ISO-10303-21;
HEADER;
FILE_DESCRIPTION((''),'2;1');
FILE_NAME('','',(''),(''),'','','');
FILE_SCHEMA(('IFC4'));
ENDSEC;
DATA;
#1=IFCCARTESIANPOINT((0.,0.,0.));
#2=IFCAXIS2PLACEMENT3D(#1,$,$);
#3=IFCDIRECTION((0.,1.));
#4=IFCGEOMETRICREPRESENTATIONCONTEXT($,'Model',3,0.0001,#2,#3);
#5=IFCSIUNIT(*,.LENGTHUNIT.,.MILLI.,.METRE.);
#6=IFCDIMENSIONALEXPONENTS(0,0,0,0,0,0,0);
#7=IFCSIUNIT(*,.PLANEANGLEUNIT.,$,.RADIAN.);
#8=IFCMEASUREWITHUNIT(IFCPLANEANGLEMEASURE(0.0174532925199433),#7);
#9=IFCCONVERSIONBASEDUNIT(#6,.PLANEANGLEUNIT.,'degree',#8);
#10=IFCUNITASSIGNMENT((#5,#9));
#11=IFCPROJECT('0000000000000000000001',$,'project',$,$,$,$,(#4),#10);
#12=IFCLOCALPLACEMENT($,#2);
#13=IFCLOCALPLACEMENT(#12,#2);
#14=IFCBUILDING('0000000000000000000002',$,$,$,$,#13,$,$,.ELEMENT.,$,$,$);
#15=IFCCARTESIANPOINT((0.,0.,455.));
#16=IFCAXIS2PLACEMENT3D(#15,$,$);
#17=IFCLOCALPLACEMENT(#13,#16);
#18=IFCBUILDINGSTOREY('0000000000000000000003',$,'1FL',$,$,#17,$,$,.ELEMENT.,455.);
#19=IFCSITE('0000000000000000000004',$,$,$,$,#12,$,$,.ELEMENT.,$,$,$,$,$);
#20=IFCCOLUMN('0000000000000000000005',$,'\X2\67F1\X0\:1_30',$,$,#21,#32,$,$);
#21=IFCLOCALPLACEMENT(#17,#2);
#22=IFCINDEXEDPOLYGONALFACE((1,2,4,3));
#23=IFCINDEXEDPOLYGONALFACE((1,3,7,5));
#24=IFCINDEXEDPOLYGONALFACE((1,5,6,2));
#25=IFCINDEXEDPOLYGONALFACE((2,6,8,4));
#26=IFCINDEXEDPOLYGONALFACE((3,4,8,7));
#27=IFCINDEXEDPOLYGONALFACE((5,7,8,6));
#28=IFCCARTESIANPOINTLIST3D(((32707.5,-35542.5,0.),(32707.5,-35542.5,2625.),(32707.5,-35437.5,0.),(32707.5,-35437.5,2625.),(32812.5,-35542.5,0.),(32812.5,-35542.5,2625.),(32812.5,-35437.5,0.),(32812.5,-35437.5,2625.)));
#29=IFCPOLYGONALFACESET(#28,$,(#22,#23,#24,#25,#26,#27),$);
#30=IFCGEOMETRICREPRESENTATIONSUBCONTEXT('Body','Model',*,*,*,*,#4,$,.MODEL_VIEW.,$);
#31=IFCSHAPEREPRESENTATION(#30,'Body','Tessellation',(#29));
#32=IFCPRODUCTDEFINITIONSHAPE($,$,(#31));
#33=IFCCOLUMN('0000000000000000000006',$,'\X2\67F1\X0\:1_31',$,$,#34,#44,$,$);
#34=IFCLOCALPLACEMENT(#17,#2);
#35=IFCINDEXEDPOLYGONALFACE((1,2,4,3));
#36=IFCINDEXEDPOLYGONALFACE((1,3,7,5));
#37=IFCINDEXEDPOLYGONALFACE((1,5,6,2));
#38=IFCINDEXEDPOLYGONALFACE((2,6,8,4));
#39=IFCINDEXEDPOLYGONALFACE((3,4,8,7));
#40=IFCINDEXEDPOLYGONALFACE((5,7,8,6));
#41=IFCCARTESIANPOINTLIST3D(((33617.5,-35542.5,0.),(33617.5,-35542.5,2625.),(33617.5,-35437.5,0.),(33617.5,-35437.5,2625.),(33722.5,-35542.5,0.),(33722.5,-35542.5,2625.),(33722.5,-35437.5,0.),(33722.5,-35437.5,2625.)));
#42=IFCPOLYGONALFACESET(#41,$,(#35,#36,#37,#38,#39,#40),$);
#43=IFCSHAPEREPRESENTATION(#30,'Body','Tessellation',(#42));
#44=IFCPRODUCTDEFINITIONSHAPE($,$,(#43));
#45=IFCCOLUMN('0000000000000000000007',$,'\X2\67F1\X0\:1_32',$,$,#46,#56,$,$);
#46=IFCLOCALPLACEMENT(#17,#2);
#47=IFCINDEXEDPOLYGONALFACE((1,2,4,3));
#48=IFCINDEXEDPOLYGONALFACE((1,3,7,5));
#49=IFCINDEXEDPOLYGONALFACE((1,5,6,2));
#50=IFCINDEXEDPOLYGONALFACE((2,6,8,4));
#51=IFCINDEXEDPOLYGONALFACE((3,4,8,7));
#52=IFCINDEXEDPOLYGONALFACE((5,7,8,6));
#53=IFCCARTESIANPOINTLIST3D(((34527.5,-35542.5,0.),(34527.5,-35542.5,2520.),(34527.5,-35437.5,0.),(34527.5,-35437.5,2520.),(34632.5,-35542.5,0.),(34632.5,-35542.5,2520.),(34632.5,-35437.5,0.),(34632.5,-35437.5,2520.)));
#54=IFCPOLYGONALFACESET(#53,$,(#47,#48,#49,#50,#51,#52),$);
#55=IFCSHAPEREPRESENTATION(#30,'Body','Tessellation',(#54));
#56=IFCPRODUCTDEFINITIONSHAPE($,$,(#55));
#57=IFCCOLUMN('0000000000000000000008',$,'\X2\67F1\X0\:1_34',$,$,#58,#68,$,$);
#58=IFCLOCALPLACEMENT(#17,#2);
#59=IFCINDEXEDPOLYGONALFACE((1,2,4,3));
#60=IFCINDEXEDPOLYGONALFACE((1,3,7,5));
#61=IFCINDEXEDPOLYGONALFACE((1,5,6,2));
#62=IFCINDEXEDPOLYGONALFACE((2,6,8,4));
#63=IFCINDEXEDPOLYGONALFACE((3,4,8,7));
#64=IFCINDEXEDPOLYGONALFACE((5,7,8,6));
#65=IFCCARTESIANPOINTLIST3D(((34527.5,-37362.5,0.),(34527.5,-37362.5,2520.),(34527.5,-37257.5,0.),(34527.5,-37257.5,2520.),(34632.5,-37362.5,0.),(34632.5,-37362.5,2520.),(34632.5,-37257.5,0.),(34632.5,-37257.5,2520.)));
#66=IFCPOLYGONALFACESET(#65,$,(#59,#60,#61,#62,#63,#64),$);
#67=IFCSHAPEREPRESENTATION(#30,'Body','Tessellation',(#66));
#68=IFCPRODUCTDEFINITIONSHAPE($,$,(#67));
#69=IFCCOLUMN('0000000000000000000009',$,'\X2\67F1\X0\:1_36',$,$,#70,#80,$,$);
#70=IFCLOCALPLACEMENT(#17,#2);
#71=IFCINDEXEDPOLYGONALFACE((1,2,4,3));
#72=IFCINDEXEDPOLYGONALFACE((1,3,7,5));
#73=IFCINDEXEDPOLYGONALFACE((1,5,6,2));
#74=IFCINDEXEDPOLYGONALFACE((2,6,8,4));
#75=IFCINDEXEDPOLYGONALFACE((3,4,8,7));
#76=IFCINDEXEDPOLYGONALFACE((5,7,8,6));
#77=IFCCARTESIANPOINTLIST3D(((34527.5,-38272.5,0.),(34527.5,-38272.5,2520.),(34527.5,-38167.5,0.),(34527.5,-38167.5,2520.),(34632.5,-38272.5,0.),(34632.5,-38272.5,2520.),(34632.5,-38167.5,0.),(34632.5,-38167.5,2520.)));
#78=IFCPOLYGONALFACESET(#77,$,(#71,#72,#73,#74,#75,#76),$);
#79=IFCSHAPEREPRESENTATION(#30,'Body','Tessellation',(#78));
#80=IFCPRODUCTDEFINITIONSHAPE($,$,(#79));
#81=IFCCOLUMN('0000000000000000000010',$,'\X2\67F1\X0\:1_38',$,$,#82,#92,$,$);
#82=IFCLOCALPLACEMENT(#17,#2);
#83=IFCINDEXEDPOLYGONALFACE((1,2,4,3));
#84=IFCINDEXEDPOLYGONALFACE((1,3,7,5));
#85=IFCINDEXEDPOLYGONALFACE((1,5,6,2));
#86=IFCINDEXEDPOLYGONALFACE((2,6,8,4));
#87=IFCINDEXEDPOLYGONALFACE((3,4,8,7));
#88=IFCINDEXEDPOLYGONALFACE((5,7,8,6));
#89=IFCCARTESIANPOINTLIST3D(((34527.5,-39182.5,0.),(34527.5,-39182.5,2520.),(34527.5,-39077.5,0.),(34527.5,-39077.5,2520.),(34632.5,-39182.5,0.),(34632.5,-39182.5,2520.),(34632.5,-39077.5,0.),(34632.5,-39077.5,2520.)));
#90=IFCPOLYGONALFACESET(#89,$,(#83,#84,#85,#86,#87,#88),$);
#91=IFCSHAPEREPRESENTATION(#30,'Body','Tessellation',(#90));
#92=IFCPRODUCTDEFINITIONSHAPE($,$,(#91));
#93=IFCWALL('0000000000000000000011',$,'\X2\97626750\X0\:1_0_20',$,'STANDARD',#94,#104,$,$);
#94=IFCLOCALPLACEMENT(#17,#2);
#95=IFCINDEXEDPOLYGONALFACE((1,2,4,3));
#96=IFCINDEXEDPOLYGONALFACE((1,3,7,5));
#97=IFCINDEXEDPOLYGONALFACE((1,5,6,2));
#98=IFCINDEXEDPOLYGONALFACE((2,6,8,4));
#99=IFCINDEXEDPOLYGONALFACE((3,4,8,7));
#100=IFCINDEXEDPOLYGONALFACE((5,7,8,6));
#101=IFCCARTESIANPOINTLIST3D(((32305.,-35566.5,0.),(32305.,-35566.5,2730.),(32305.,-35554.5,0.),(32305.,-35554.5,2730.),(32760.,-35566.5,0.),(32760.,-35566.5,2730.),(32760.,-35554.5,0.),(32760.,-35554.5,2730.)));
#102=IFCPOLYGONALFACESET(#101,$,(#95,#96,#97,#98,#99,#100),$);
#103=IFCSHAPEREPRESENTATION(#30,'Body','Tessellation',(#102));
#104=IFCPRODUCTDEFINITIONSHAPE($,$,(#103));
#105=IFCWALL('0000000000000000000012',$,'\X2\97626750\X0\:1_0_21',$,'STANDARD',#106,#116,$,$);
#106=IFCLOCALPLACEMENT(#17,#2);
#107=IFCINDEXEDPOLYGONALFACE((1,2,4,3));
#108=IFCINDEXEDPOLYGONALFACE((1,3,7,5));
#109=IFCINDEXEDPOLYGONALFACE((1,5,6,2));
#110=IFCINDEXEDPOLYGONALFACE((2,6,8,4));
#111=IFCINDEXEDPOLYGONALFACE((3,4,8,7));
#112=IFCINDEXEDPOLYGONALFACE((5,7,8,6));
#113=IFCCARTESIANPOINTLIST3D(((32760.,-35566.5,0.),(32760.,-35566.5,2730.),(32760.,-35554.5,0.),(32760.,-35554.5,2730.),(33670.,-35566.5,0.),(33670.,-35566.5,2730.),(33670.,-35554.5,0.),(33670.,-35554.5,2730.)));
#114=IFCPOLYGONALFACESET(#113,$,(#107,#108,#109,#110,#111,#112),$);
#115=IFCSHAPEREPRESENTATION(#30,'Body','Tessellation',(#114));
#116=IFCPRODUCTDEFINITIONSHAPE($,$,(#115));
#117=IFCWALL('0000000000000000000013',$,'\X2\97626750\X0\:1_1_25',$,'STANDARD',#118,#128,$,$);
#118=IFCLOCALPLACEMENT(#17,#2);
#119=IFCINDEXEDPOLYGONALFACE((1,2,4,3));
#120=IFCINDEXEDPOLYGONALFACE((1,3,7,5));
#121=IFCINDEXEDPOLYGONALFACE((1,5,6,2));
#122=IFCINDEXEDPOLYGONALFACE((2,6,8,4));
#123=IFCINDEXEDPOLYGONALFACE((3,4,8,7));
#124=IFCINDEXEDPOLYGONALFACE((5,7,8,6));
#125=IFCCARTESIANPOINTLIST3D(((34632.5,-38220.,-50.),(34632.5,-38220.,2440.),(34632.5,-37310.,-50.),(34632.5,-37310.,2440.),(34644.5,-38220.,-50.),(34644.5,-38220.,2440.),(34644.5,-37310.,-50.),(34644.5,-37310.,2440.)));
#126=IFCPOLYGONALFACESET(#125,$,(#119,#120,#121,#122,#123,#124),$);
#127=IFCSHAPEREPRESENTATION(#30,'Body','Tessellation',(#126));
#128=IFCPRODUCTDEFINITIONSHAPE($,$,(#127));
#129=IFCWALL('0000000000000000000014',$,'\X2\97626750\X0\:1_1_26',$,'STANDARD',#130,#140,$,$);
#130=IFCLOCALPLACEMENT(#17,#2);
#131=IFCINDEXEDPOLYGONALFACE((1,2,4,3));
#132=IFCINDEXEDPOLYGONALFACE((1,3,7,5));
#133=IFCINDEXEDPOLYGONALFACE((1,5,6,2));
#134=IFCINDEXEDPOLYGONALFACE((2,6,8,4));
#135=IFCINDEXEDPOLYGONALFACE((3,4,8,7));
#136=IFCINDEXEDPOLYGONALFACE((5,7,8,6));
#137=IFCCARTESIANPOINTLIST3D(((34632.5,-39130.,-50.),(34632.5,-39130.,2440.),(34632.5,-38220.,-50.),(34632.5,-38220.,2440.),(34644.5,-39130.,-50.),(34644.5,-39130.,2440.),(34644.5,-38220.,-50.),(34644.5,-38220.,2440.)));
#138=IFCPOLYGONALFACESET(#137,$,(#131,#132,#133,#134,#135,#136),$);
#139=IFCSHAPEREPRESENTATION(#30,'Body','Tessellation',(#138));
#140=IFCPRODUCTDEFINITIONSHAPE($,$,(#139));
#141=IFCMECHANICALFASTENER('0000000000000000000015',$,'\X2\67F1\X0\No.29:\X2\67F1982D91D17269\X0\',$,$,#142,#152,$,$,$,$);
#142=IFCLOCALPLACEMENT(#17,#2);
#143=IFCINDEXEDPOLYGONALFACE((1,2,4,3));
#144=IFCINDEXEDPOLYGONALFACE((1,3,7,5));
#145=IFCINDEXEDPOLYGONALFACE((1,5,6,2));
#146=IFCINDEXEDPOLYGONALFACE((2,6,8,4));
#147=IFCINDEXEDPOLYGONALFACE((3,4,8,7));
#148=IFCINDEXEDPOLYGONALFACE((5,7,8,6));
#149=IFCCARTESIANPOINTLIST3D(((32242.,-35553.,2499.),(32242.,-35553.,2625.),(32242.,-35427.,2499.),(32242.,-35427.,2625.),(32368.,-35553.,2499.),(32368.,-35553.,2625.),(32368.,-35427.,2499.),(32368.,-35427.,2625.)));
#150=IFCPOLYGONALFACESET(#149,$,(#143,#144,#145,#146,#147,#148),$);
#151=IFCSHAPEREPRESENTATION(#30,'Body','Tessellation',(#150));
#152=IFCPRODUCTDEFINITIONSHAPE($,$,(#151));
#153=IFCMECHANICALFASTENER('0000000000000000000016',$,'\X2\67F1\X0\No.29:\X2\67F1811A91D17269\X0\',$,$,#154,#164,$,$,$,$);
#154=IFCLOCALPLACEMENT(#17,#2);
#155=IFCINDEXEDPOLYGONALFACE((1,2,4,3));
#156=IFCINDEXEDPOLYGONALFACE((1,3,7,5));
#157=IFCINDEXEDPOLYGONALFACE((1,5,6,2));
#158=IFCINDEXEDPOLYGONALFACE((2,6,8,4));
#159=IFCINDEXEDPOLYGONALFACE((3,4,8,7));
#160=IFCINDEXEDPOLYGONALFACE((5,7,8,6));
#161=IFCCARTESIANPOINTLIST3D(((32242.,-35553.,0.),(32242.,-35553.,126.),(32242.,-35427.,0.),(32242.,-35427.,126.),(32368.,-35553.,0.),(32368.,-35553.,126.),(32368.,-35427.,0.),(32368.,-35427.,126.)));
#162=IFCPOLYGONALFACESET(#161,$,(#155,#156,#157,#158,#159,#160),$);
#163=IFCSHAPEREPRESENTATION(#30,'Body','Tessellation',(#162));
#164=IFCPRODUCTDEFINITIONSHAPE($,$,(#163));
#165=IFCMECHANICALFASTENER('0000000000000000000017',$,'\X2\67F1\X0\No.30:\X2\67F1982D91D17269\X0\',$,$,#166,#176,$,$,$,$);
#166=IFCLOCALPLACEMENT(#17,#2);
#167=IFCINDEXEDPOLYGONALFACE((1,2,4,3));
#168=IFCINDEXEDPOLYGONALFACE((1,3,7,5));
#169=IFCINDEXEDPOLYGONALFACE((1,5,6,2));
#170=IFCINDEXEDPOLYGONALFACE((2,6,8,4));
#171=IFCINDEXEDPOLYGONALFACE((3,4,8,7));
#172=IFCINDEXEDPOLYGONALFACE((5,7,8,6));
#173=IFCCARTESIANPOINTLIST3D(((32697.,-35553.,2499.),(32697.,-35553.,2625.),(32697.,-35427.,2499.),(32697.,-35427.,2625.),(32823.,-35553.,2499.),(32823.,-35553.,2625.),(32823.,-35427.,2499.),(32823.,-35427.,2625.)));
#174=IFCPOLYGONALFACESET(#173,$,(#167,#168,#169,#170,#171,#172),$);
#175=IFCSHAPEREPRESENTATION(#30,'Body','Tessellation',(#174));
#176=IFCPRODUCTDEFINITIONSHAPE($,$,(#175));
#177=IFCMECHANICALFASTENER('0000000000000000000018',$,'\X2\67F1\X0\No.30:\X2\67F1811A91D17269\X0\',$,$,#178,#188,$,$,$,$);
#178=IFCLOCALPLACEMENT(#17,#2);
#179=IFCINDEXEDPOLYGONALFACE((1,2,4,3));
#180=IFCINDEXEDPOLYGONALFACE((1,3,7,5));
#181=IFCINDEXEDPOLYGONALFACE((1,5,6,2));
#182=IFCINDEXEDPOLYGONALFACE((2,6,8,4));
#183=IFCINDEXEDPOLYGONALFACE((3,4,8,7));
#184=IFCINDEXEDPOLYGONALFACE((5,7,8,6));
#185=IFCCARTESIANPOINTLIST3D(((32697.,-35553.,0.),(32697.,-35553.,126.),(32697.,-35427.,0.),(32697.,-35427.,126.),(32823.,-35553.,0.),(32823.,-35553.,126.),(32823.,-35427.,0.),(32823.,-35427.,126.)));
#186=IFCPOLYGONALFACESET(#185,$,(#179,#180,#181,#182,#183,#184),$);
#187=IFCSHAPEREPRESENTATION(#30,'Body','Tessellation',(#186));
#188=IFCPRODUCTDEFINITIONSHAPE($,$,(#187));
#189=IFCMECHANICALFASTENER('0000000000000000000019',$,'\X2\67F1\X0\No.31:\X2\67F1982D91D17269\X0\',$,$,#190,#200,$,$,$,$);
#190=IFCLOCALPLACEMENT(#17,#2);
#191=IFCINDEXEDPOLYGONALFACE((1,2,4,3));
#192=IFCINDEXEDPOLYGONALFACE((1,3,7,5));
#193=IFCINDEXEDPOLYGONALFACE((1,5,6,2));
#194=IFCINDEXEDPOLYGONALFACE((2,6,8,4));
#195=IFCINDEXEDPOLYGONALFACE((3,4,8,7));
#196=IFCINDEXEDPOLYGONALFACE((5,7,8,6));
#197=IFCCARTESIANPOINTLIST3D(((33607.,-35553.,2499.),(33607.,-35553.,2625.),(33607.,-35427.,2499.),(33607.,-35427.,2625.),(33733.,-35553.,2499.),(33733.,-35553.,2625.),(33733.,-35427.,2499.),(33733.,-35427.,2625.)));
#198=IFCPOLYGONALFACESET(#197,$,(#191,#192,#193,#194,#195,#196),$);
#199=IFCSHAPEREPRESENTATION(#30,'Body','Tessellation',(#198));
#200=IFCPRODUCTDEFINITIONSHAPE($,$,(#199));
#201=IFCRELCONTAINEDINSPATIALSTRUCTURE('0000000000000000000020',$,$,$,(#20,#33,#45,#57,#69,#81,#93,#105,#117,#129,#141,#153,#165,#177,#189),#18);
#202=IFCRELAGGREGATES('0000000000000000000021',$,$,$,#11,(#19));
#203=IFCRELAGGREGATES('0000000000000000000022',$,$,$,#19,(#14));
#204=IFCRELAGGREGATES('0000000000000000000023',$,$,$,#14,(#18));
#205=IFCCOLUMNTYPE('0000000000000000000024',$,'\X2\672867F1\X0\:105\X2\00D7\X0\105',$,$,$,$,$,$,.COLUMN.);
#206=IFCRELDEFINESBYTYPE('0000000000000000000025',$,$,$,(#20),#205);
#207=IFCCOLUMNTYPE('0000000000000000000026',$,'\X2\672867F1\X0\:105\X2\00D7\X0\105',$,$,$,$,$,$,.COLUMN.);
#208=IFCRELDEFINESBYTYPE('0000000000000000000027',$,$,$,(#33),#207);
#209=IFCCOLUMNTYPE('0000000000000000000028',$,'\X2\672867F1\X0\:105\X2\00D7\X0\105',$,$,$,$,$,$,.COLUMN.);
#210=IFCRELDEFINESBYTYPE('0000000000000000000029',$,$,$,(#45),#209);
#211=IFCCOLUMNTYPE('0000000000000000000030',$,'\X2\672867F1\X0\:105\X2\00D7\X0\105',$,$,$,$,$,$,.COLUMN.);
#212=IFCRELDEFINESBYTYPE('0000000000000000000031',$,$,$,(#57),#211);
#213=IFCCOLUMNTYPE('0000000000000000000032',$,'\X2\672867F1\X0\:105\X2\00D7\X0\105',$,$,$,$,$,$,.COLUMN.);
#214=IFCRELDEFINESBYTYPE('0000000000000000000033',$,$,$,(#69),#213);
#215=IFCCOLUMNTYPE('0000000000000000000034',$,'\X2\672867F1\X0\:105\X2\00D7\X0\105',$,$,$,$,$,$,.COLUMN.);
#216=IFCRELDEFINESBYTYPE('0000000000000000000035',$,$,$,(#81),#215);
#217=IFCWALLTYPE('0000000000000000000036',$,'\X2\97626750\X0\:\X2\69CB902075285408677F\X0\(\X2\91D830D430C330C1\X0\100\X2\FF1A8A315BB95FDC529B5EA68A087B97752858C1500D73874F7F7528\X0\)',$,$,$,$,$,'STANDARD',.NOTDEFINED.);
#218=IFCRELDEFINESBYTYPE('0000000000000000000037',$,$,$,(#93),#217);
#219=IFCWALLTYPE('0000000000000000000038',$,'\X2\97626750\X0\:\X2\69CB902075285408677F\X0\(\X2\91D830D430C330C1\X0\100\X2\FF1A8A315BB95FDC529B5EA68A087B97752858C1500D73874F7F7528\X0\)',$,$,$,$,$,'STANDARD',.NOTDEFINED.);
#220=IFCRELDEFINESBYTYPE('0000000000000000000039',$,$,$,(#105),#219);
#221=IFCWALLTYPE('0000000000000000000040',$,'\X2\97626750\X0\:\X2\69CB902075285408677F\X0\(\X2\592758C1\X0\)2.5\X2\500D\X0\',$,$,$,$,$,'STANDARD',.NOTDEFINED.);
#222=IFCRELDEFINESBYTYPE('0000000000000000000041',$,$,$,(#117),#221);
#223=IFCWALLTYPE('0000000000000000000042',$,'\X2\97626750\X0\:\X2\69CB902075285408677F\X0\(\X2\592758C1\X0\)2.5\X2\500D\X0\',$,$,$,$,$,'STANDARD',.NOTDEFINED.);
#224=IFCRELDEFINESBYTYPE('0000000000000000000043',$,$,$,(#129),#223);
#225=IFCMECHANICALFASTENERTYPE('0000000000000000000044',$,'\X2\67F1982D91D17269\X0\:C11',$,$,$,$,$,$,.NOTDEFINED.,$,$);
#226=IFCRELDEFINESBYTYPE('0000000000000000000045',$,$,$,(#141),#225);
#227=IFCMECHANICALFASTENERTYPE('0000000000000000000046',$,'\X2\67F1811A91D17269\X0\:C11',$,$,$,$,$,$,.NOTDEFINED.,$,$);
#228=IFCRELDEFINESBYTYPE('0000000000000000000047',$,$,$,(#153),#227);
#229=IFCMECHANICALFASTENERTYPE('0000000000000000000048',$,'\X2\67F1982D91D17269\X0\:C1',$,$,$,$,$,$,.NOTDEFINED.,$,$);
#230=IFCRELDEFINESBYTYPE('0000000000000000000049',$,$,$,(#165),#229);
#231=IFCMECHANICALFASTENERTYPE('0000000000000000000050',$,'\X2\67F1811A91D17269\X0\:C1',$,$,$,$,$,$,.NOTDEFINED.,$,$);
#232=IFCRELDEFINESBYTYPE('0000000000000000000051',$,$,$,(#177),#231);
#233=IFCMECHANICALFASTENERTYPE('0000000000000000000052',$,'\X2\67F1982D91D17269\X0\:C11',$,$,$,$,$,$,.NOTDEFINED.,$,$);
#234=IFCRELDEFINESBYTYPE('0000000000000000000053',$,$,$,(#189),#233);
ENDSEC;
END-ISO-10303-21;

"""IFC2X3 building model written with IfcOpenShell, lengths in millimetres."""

from ifc_helpers import new_model, entity, si_unit, converted_unit, direction, frame, origin, origin_with_axes, origin_2d, place, context, subcontext, project, spatial, polyline, rectangle, outline, extrude, type_object, element, save


model = new_model("IFC2X3")

# Units and contexts
model_context = context("Model", 3, precision=0.0001, world=origin(), true_north=direction((0.0, 1.0)))
body_context = subcontext(model_context, "Body", "Model", "MODEL_VIEW")
ifc_project = project(units=[si_unit("LENGTHUNIT", "METRE", prefix="MILLI"), converted_unit("PLANEANGLEUNIT", "degree", entity("IfcPlaneAngleMeasure", 0.0174532925199433), si_unit("PLANEANGLEUNIT", "RADIAN"), dimensions=[0, 0, 0, 0, 0, 0, 0])], contexts=[model_context])

# Site, building, storey
site_placement = place(None, origin())
site = spatial("IfcSite", under=ifc_project, at=site_placement, CompositionType="ELEMENT")
building_placement = place(site_placement, origin())
building = spatial("IfcBuilding", under=site, at=building_placement, CompositionType="ELEMENT")
storey_placement = place(building_placement, frame((0.0, 0.0, 455.0)))
storey = spatial("IfcBuildingStorey", under=building, at=storey_placement, Name="1FL", CompositionType="ELEMENT", Elevation=455.0)

# Columns
column_type_1 = type_object("IfcColumnType", Name="木柱:105×105", PredefinedType="COLUMN")
column_1_placement = place(storey_placement, frame((32760.0, -35490.0, 0.0)))
element("IfcColumn", 1, at=column_1_placement, inside=storey, type_object=column_type_1, Name="柱:1_30", context=body_context, shape_type="SweptSolid", body=[
    extrude(rectangle(XDim=105.0, YDim=105.0, at=origin_2d()), origin_with_axes(), (0.0, 0.0, 1.0), 2625.0),
])
column_type_2 = type_object("IfcColumnType", Name="木柱:105×105", PredefinedType="COLUMN")
column_2_placement = place(storey_placement, frame((33670.0, -35490.0, 0.0)))
element("IfcColumn", 2, at=column_2_placement, inside=storey, type_object=column_type_2, Name="柱:1_31", context=body_context, shape_type="SweptSolid", body=[
    extrude(rectangle(XDim=105.0, YDim=105.0, at=origin_2d()), origin_with_axes(), (0.0, 0.0, 1.0), 2625.0),
])
column_type_3 = type_object("IfcColumnType", Name="木柱:105×105", PredefinedType="COLUMN")
column_3_placement = place(storey_placement, frame((34580.0, -35490.0, 0.0)))
element("IfcColumn", 3, at=column_3_placement, inside=storey, type_object=column_type_3, Name="柱:1_32", context=body_context, shape_type="SweptSolid", body=[
    extrude(rectangle(XDim=105.0, YDim=105.0, at=origin_2d()), origin_with_axes(), (0.0, 0.0, 1.0), 2520.0),
])
column_type_4 = type_object("IfcColumnType", Name="木柱:105×105", PredefinedType="COLUMN")
column_4_placement = place(storey_placement, frame((34580.0, -37310.0, 0.0)))
element("IfcColumn", 4, at=column_4_placement, inside=storey, type_object=column_type_4, Name="柱:1_34", context=body_context, shape_type="SweptSolid", body=[
    extrude(rectangle(XDim=105.0, YDim=105.0, at=origin_2d()), origin_with_axes(), (0.0, 0.0, 1.0), 2520.0),
])
column_type_5 = type_object("IfcColumnType", Name="木柱:105×105", PredefinedType="COLUMN")
column_5_placement = place(storey_placement, frame((34580.0, -38220.0, 0.0)))
element("IfcColumn", 5, at=column_5_placement, inside=storey, type_object=column_type_5, Name="柱:1_36", context=body_context, shape_type="SweptSolid", body=[
    extrude(rectangle(XDim=105.0, YDim=105.0, at=origin_2d()), origin_with_axes(), (0.0, 0.0, 1.0), 2520.0),
])
column_type_6 = type_object("IfcColumnType", Name="木柱:105×105", PredefinedType="COLUMN")
column_6_placement = place(storey_placement, frame((34580.0, -39130.0, 0.0)))
element("IfcColumn", 6, at=column_6_placement, inside=storey, type_object=column_type_6, Name="柱:1_38", context=body_context, shape_type="SweptSolid", body=[
    extrude(rectangle(XDim=105.0, YDim=105.0, at=origin_2d()), origin_with_axes(), (0.0, 0.0, 1.0), 2520.0),
])

# Walls
wall_type_1 = type_object("IfcWallType", Name="面材:構造用合板(釘ピッチ100：許容応力度計算用壁倍率使用)", ElementType="STANDARD", PredefinedType="NOTDEFINED")
wall_1_placement = place(storey_placement, frame((32532.5, -35554.5, 0.0), z_axis=(0.0, -1.0, 0.0), x_axis=(1.0, 0.0, 0.0)))
element("IfcWall", 7, at=wall_1_placement, inside=storey, type_object=wall_type_1, Name="面材:1_0_20", ObjectType="STANDARD", context=body_context, shape_type="SweptSolid", body=[
    extrude(outline(polyline([(227.5, 0.0, 0.0), (-227.5, 0.0, 0.0), (-227.5, 2730.0, 0.0), (227.5, 2730.0, 0.0), (227.5, 0.0, 0.0)])), origin_with_axes(), (0.0, 0.0, 1.0), 12.0),
])
wall_type_2 = type_object("IfcWallType", Name="面材:構造用合板(釘ピッチ100：許容応力度計算用壁倍率使用)", ElementType="STANDARD", PredefinedType="NOTDEFINED")
wall_2_placement = place(storey_placement, frame((33215.0, -35554.5, 0.0), z_axis=(0.0, -1.0, 0.0), x_axis=(1.0, 0.0, 0.0)))
element("IfcWall", 8, at=wall_2_placement, inside=storey, type_object=wall_type_2, Name="面材:1_0_21", ObjectType="STANDARD", context=body_context, shape_type="SweptSolid", body=[
    extrude(outline(polyline([(455.0, 0.0, 0.0), (-455.0, 0.0, 0.0), (-455.0, 2730.0, 0.0), (455.0, 2730.0, 0.0), (455.0, 0.0, 0.0)])), origin_with_axes(), (0.0, 0.0, 1.0), 12.0),
])
wall_type_3 = type_object("IfcWallType", Name="面材:構造用合板(大壁)2.5倍", ElementType="STANDARD", PredefinedType="NOTDEFINED")
wall_3_placement = place(storey_placement, frame((34644.5, -37765.0, -50.0), z_axis=(-1.0, 0.0, 0.0), x_axis=(0.0, -1.0, 0.0)))
element("IfcWall", 9, at=wall_3_placement, inside=storey, type_object=wall_type_3, Name="面材:1_1_25", ObjectType="STANDARD", context=body_context, shape_type="SweptSolid", body=[
    extrude(outline(polyline([(455.0, 0.0, 0.0), (-455.0, 0.0, 0.0), (-455.0, 2490.0, 0.0), (455.0, 2490.0, 0.0), (455.0, 0.0, 0.0)])), origin_with_axes(), (0.0, 0.0, 1.0), 12.0),
])
wall_type_4 = type_object("IfcWallType", Name="面材:構造用合板(大壁)2.5倍", ElementType="STANDARD", PredefinedType="NOTDEFINED")
wall_4_placement = place(storey_placement, frame((34644.5, -38675.0, -50.0), z_axis=(-1.0, 0.0, 0.0), x_axis=(0.0, -1.0, 0.0)))
element("IfcWall", 10, at=wall_4_placement, inside=storey, type_object=wall_type_4, Name="面材:1_1_26", ObjectType="STANDARD", context=body_context, shape_type="SweptSolid", body=[
    extrude(outline(polyline([(455.0, 0.0, 0.0), (-455.0, 0.0, 0.0), (-455.0, 2490.0, 0.0), (455.0, 2490.0, 0.0), (455.0, 0.0, 0.0)])), origin_with_axes(), (0.0, 0.0, 1.0), 12.0),
])

# Mechanical fasteners
mechanical_fastener_type_1 = type_object("IfcMechanicalFastenerType", Name="柱頭金物:C11")
mechanical_fastener_1_placement = place(storey_placement, frame((32305.0, -35490.0, 2499.0)))
element("IfcMechanicalFastener", 11, at=mechanical_fastener_1_placement, inside=storey, type_object=mechanical_fastener_type_1, Name="柱No.29:柱頭金物", context=body_context, shape_type="SweptSolid", body=[
    extrude(rectangle(XDim=126.0, YDim=126.0, at=origin_2d()), origin_with_axes(), (0.0, 0.0, 1.0), 126.0),
])
mechanical_fastener_type_2 = type_object("IfcMechanicalFastenerType", Name="柱脚金物:C11")
mechanical_fastener_2_placement = place(storey_placement, frame((32305.0, -35490.0, 0.0)))
element("IfcMechanicalFastener", 12, at=mechanical_fastener_2_placement, inside=storey, type_object=mechanical_fastener_type_2, Name="柱No.29:柱脚金物", context=body_context, shape_type="SweptSolid", body=[
    extrude(rectangle(XDim=126.0, YDim=126.0, at=origin_2d()), origin_with_axes(), (0.0, 0.0, 1.0), 126.0),
])
mechanical_fastener_type_3 = type_object("IfcMechanicalFastenerType", Name="柱頭金物:C1")
mechanical_fastener_3_placement = place(storey_placement, frame((32760.0, -35490.0, 2499.0)))
element("IfcMechanicalFastener", 13, at=mechanical_fastener_3_placement, inside=storey, type_object=mechanical_fastener_type_3, Name="柱No.30:柱頭金物", context=body_context, shape_type="SweptSolid", body=[
    extrude(rectangle(XDim=126.0, YDim=126.0, at=origin_2d()), origin_with_axes(), (0.0, 0.0, 1.0), 126.0),
])
mechanical_fastener_type_4 = type_object("IfcMechanicalFastenerType", Name="柱脚金物:C1")
mechanical_fastener_4_placement = place(storey_placement, frame((32760.0, -35490.0, 0.0)))
element("IfcMechanicalFastener", 14, at=mechanical_fastener_4_placement, inside=storey, type_object=mechanical_fastener_type_4, Name="柱No.30:柱脚金物", context=body_context, shape_type="SweptSolid", body=[
    extrude(rectangle(XDim=126.0, YDim=126.0, at=origin_2d()), origin_with_axes(), (0.0, 0.0, 1.0), 126.0),
])
mechanical_fastener_type_5 = type_object("IfcMechanicalFastenerType", Name="柱頭金物:C11")
mechanical_fastener_5_placement = place(storey_placement, frame((33670.0, -35490.0, 2499.0)))
element("IfcMechanicalFastener", 15, at=mechanical_fastener_5_placement, inside=storey, type_object=mechanical_fastener_type_5, Name="柱No.31:柱頭金物", context=body_context, shape_type="SweptSolid", body=[
    extrude(rectangle(XDim=126.0, YDim=126.0, at=origin_2d()), origin_with_axes(), (0.0, 0.0, 1.0), 126.0),
])

save(model, "model.ifc")
